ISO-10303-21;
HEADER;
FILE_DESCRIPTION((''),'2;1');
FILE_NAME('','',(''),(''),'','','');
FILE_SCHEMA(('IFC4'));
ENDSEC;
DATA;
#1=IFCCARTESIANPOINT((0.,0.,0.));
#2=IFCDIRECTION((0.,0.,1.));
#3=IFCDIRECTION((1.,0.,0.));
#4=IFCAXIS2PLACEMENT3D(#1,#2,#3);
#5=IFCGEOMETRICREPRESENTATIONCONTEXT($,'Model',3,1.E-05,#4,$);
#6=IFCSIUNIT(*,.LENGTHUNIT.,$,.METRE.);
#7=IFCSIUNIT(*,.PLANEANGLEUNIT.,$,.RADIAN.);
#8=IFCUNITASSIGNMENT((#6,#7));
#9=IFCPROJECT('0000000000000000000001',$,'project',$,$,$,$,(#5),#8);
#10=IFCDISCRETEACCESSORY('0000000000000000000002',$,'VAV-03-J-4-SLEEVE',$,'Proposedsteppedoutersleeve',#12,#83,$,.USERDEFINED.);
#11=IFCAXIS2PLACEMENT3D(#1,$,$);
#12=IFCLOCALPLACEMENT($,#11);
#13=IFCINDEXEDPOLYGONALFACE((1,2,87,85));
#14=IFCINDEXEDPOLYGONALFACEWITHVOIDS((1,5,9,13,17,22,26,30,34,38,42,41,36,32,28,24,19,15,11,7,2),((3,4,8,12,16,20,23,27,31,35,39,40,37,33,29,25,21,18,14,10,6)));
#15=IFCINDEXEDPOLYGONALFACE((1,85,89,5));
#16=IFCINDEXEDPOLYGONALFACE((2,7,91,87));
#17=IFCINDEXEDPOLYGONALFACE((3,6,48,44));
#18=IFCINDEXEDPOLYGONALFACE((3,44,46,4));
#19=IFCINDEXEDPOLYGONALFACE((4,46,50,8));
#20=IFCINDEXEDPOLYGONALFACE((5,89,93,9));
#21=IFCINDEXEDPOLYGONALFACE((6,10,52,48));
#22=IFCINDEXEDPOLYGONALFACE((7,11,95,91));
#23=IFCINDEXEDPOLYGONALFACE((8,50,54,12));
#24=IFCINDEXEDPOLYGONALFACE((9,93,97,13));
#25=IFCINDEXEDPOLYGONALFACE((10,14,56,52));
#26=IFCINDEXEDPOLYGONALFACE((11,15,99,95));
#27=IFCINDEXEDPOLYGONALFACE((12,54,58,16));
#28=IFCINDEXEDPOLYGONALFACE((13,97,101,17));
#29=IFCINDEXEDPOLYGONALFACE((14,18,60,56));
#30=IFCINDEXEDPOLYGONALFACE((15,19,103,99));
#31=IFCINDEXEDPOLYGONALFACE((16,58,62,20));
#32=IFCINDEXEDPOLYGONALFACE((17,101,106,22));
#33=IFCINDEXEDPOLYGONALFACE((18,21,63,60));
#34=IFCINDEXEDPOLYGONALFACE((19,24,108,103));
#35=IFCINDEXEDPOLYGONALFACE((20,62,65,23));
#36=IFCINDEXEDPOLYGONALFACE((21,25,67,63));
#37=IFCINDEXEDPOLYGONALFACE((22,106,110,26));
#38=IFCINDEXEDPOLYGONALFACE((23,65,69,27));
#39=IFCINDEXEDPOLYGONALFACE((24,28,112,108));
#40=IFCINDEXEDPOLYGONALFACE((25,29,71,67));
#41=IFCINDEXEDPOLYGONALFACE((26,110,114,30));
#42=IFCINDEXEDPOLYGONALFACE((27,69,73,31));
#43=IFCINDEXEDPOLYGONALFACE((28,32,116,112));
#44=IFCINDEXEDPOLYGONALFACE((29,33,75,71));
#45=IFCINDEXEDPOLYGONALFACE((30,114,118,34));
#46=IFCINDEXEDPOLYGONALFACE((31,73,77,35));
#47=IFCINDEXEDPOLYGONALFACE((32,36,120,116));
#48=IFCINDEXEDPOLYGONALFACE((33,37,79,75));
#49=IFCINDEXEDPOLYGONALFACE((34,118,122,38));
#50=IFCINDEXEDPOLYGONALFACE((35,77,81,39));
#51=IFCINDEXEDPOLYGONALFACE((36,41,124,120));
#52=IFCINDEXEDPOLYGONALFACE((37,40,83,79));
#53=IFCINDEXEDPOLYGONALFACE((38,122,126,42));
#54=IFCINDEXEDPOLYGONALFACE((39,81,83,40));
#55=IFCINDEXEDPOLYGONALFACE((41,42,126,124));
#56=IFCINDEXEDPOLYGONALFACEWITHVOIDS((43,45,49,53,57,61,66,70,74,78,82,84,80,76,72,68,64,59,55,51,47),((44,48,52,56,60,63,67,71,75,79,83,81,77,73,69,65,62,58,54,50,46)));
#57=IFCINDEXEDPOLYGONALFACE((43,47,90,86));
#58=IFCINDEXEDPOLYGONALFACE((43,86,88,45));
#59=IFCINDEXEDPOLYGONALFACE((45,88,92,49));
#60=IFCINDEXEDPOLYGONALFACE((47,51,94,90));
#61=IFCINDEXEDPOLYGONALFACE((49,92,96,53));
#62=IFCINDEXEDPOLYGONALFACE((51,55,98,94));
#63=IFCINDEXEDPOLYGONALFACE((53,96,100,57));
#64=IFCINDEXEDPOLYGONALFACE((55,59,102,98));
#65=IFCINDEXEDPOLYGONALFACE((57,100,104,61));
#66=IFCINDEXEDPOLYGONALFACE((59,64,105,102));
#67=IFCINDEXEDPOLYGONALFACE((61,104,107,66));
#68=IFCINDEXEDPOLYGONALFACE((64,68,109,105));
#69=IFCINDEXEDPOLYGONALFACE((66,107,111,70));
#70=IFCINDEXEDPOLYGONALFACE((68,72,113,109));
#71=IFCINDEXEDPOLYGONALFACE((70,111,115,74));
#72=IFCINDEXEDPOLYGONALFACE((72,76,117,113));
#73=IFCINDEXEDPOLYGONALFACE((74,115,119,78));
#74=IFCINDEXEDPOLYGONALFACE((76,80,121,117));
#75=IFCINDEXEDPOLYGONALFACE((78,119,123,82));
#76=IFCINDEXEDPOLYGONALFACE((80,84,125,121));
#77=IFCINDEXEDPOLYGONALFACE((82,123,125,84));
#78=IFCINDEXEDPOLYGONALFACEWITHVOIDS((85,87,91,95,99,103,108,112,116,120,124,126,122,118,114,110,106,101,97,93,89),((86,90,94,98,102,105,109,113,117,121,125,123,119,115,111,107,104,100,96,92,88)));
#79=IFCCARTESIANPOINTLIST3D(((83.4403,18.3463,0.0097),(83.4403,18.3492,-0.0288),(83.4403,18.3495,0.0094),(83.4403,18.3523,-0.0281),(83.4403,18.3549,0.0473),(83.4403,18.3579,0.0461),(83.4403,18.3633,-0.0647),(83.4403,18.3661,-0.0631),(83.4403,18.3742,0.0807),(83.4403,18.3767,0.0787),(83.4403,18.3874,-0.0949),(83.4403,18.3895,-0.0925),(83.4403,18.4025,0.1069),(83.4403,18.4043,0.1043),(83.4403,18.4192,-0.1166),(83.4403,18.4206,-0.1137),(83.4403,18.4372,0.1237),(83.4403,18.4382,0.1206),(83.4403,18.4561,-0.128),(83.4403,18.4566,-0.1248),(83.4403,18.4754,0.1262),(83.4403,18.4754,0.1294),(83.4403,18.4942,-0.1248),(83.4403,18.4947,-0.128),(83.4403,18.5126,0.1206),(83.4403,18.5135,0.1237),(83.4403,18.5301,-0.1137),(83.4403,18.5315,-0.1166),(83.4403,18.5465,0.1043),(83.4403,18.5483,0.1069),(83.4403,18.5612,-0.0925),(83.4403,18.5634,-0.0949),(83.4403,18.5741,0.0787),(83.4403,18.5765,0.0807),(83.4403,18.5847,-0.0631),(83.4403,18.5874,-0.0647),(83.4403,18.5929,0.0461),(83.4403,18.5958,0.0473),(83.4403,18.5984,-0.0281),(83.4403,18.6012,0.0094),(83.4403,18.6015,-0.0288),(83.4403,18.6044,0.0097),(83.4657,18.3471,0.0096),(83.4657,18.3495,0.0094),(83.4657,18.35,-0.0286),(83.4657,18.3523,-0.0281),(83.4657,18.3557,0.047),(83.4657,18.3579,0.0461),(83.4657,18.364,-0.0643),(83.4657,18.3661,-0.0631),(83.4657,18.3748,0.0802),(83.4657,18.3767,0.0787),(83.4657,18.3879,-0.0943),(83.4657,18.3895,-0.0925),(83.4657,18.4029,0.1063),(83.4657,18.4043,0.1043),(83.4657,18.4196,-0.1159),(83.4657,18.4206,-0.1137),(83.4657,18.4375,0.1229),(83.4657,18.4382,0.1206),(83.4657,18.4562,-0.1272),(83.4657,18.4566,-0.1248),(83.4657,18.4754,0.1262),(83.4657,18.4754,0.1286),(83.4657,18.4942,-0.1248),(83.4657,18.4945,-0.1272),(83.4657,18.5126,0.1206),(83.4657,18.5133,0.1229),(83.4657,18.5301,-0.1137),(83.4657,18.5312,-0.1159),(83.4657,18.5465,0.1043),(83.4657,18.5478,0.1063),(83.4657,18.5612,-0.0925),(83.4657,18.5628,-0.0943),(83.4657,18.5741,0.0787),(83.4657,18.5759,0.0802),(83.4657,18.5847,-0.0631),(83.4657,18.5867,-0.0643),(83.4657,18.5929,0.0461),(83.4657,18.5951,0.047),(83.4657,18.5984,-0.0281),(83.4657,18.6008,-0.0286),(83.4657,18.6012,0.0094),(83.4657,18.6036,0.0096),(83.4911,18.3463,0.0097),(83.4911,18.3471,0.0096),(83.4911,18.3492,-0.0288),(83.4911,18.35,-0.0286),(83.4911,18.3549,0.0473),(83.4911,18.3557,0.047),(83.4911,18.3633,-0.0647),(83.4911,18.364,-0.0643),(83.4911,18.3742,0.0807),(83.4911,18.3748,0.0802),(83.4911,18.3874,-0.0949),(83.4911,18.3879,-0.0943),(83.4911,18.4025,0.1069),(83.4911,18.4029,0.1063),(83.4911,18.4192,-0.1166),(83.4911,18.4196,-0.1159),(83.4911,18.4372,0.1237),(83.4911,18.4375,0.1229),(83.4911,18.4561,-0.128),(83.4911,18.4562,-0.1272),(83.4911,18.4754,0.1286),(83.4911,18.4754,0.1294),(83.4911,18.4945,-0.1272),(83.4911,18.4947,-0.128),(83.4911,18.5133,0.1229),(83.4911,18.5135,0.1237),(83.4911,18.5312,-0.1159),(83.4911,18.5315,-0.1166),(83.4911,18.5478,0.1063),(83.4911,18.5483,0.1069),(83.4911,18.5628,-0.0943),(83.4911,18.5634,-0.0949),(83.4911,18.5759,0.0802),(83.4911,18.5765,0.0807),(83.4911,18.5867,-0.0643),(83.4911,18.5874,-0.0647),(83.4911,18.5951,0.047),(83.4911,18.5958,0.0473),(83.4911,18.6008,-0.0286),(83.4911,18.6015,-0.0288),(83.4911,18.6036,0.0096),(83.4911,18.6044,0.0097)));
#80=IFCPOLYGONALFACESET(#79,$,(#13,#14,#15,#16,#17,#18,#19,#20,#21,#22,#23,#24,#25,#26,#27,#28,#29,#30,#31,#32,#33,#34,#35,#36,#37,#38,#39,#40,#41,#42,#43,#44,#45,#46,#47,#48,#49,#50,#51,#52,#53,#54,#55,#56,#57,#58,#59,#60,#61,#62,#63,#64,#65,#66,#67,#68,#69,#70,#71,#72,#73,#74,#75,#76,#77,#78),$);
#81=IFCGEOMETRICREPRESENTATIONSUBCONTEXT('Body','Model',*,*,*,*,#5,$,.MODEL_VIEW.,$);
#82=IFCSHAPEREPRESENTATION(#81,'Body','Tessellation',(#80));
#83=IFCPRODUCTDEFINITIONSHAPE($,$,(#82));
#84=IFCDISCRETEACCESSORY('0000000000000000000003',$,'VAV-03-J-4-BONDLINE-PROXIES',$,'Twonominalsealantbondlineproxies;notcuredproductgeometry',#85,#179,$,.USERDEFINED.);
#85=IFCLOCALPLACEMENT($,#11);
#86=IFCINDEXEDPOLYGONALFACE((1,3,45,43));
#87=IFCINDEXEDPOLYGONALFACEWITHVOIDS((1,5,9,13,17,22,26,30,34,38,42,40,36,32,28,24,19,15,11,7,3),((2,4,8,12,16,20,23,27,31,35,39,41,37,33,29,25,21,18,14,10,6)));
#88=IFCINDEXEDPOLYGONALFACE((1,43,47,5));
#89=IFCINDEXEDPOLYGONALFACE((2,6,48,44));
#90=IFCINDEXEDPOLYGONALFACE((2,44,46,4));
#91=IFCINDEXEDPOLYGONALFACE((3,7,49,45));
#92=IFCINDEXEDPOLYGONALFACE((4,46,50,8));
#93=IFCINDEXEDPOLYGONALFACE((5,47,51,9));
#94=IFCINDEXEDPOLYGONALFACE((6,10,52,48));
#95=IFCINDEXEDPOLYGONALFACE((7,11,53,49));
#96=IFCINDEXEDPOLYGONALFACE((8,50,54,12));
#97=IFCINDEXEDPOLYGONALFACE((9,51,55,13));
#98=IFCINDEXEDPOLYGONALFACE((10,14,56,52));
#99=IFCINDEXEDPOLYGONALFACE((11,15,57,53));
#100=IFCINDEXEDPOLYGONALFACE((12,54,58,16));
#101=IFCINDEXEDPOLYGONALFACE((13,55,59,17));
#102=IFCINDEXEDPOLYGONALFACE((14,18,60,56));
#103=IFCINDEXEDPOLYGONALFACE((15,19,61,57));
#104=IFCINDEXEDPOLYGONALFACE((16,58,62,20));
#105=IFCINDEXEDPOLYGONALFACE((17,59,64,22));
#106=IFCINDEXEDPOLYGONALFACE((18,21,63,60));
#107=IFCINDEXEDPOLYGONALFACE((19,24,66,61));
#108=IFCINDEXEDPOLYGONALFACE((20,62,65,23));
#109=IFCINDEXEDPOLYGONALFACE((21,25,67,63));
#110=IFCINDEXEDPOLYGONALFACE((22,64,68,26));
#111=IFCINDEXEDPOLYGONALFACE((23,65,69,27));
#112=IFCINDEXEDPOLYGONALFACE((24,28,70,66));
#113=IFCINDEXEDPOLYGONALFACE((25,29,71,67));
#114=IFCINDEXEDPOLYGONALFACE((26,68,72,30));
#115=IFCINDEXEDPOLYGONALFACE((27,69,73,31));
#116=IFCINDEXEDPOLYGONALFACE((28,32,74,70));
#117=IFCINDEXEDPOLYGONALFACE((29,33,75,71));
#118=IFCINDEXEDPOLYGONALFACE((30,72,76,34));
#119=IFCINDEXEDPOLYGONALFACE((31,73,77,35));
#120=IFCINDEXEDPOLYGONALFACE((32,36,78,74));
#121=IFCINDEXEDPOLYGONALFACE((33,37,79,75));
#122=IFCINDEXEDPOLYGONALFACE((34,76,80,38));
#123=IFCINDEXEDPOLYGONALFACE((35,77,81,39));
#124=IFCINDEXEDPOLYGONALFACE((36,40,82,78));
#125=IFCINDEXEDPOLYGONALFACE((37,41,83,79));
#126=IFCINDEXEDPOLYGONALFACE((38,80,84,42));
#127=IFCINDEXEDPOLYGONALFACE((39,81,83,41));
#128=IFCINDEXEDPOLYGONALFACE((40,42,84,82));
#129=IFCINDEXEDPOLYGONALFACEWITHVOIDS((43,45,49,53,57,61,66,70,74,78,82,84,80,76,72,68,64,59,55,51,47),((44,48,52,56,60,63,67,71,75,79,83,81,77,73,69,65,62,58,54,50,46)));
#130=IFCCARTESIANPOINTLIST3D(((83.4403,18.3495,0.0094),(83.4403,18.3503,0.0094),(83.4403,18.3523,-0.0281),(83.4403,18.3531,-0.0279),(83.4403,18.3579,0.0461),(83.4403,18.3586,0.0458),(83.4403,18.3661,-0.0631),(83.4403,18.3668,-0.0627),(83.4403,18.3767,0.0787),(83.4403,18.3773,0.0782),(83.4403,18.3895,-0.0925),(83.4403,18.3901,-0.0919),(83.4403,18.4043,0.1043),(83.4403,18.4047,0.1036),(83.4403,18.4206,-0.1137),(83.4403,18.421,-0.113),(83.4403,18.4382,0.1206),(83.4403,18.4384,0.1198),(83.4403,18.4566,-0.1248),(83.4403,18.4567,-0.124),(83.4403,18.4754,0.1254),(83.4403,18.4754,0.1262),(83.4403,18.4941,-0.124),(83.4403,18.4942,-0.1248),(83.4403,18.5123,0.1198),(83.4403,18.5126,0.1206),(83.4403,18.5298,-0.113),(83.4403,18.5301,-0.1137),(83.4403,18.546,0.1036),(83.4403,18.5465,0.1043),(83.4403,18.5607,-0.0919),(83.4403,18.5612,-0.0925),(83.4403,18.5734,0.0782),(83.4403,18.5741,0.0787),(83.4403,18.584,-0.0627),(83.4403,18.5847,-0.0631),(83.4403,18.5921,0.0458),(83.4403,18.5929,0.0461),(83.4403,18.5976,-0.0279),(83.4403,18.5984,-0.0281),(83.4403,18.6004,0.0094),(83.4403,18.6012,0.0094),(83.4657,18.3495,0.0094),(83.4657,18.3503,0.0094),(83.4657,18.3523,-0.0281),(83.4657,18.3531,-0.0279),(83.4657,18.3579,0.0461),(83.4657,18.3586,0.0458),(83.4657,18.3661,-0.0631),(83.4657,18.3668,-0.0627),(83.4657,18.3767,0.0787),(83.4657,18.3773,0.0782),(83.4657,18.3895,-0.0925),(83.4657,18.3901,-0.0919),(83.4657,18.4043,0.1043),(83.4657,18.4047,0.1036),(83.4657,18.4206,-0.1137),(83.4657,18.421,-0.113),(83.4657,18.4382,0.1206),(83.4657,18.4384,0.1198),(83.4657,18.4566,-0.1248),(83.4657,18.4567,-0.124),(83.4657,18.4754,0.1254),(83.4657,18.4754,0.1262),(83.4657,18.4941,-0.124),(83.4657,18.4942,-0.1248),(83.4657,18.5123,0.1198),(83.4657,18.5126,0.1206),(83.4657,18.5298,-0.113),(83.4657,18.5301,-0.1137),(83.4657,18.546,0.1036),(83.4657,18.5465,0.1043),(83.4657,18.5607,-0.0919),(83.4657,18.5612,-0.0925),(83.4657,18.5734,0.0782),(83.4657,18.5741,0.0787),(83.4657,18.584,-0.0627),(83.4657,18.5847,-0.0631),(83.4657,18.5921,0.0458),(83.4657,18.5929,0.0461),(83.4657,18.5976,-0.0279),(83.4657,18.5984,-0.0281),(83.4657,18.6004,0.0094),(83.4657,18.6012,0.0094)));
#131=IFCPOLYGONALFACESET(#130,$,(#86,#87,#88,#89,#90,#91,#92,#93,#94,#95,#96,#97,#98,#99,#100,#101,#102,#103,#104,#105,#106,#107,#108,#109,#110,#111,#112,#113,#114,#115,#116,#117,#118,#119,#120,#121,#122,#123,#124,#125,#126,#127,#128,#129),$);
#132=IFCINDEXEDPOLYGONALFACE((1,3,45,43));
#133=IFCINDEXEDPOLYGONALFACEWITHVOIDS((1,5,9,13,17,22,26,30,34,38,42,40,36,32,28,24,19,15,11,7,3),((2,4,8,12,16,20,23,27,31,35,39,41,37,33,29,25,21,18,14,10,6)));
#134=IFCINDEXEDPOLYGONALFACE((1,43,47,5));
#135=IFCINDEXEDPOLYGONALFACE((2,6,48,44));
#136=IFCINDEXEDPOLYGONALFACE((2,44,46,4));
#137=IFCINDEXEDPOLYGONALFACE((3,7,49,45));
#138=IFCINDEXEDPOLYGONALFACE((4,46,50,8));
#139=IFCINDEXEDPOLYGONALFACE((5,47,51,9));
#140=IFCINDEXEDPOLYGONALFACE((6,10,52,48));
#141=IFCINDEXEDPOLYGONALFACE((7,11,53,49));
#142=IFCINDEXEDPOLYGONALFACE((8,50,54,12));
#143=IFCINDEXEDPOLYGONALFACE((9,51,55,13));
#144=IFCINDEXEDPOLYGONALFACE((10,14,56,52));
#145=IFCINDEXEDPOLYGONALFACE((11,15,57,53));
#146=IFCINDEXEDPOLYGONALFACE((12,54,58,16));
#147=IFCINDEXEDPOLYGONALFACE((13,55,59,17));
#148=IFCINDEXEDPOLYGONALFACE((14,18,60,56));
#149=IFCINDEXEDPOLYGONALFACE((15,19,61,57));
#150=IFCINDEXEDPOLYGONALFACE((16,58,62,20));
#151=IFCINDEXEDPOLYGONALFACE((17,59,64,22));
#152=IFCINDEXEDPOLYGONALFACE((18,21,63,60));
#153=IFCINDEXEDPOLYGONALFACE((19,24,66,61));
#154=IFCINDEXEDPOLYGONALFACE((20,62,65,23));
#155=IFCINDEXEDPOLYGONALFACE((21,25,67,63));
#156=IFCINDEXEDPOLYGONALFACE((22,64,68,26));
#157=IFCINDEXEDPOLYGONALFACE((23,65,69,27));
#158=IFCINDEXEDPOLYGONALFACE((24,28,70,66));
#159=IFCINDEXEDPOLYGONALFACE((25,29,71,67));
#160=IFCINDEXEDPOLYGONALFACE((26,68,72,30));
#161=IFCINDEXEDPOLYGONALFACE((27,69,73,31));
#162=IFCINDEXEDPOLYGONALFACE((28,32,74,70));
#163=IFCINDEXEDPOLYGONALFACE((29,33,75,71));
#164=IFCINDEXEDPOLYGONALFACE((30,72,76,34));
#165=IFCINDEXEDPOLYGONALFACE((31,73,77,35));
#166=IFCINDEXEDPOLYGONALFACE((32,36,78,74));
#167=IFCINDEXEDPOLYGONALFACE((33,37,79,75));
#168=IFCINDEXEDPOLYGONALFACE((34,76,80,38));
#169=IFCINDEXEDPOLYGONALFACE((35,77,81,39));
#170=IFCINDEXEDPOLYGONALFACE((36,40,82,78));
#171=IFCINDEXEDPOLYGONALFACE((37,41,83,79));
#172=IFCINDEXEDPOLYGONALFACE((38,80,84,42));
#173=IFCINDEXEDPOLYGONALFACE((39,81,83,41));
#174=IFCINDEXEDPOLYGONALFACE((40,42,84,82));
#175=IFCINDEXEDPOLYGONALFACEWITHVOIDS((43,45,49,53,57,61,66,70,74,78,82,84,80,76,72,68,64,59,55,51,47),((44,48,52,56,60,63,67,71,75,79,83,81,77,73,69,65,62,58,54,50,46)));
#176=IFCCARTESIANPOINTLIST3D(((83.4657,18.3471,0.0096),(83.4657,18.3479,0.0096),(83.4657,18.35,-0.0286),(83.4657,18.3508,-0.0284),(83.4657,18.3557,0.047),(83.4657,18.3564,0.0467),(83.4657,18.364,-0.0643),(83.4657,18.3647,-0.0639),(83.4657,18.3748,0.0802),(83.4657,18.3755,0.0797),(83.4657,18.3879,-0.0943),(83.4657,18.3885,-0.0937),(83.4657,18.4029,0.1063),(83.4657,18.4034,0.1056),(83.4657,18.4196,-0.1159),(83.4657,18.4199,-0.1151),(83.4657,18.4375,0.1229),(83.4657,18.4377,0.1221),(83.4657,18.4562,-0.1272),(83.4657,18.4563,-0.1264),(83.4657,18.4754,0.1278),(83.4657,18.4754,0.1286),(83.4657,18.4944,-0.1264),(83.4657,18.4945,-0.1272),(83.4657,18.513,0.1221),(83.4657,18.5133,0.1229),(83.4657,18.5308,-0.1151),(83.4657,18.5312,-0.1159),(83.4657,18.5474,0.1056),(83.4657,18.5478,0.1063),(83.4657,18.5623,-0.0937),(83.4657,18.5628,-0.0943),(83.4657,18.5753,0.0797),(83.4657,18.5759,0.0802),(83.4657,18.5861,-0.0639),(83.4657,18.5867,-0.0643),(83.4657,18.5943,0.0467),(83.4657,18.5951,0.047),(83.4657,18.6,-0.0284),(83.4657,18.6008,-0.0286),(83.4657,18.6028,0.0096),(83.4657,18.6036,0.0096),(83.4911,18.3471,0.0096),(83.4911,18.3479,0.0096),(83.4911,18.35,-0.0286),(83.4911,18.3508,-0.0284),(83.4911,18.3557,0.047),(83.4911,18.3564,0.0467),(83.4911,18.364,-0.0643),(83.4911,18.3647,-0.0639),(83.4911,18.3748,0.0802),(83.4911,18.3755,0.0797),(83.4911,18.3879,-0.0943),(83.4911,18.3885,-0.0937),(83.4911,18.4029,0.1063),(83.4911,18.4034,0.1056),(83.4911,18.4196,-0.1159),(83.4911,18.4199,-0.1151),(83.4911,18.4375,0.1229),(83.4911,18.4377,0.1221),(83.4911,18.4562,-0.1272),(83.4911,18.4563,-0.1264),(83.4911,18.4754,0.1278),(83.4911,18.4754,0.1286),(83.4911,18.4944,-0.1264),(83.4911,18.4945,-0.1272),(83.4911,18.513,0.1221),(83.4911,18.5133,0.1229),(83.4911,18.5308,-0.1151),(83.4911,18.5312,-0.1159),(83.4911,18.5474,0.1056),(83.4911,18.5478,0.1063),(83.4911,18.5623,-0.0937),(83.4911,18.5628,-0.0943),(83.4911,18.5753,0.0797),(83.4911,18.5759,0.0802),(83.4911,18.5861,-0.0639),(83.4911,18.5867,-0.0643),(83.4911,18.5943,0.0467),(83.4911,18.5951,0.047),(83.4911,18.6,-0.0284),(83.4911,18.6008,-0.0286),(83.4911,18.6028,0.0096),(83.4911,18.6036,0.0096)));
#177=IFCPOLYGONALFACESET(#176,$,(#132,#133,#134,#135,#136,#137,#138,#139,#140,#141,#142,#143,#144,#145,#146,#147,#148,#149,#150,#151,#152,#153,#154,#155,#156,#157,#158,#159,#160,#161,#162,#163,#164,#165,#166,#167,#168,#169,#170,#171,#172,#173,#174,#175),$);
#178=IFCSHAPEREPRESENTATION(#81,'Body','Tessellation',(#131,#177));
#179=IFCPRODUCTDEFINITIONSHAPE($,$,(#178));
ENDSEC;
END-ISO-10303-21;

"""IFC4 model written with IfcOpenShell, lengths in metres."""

from ifc_helpers import new_model, entity, si_unit, frame, origin_with_axes, place, context, subcontext, project, element, save


model = new_model("IFC4")

# Units and contexts
model_context = context("Model", 3, precision=1e-05, world=origin_with_axes())
body_context = subcontext(model_context, "Body", "Model", "MODEL_VIEW")
ifc_project = project(units=[si_unit("LENGTHUNIT", "METRE"), si_unit("PLANEANGLEUNIT", "RADIAN")], contexts=[model_context])

# Discrete accessories
discrete_accessory_1_placement = place(None, frame((83.4657, 18.4754, 0.0), z_axis=(0.0, 1.0, 0.0), x_axis=(0.0, 0.0, 1.0)))
element("IfcDiscreteAccessory", 1, at=discrete_accessory_1_placement, Name="VAV-03-J-4-SLEEVE", ObjectType="Proposedsteppedoutersleeve", PredefinedType="USERDEFINED", context=body_context, shape_type="SweptSolid", body=[
    entity("IfcRevolvedAreaSolid", entity("IfcArbitraryClosedProfileDef", "AREA", None, entity("IfcPolyline", [entity("IfcCartesianPoint", [0.1262, -0.0254]), entity("IfcCartesianPoint", [0.1294, -0.0254]), entity("IfcCartesianPoint", [0.1294, 0.0254]), entity("IfcCartesianPoint", [0.1286, 0.0254]), entity("IfcCartesianPoint", [0.1286, 0.0]), entity("IfcCartesianPoint", [0.1262, 0.0]), entity("IfcCartesianPoint", [0.1262, -0.0254])])), entity("IfcAxis2Placement3D", entity("IfcCartesianPoint", [0.0, 0.0, 0.0])), entity("IfcAxis1Placement", entity("IfcCartesianPoint", [0.0, 0.0, 0.0]), entity("IfcDirection", [0.0, 1.0, 0.0])), 6.283185),
])
discrete_accessory_2_placement = place(None, frame((83.4657, 18.4754, 0.0), z_axis=(0.0, 1.0, 0.0), x_axis=(0.0, 0.0, 1.0)))
element("IfcDiscreteAccessory", 2, at=discrete_accessory_2_placement, Name="VAV-03-J-4-BONDLINE-PROXIES", ObjectType="Twonominalsealantbondlineproxies;notcuredproductgeometry", PredefinedType="USERDEFINED", context=body_context, shape_type="SweptSolid", body=[
    entity("IfcRevolvedAreaSolid", entity("IfcArbitraryClosedProfileDef", "AREA", None, entity("IfcPolyline", [entity("IfcCartesianPoint", [0.1254, -0.0254]), entity("IfcCartesianPoint", [0.1262, -0.0254]), entity("IfcCartesianPoint", [0.1262, 0.0]), entity("IfcCartesianPoint", [0.1254, 0.0]), entity("IfcCartesianPoint", [0.1254, -0.0254])])), entity("IfcAxis2Placement3D", entity("IfcCartesianPoint", [0.0, 0.0, 0.0])), entity("IfcAxis1Placement", entity("IfcCartesianPoint", [0.0, 0.0, 0.0]), entity("IfcDirection", [0.0, 1.0, 0.0])), 6.283185),
    entity("IfcRevolvedAreaSolid", entity("IfcArbitraryClosedProfileDef", "AREA", None, entity("IfcPolyline", [entity("IfcCartesianPoint", [0.1278, 0.0]), entity("IfcCartesianPoint", [0.1286, 0.0]), entity("IfcCartesianPoint", [0.1286, 0.0254]), entity("IfcCartesianPoint", [0.1278, 0.0254]), entity("IfcCartesianPoint", [0.1278, 0.0])])), entity("IfcAxis2Placement3D", entity("IfcCartesianPoint", [0.0, 0.0, 0.0])), entity("IfcAxis1Placement", entity("IfcCartesianPoint", [0.0, 0.0, 0.0]), entity("IfcDirection", [0.0, 1.0, 0.0])), 6.283185),
])

save(model, "model.ifc")
